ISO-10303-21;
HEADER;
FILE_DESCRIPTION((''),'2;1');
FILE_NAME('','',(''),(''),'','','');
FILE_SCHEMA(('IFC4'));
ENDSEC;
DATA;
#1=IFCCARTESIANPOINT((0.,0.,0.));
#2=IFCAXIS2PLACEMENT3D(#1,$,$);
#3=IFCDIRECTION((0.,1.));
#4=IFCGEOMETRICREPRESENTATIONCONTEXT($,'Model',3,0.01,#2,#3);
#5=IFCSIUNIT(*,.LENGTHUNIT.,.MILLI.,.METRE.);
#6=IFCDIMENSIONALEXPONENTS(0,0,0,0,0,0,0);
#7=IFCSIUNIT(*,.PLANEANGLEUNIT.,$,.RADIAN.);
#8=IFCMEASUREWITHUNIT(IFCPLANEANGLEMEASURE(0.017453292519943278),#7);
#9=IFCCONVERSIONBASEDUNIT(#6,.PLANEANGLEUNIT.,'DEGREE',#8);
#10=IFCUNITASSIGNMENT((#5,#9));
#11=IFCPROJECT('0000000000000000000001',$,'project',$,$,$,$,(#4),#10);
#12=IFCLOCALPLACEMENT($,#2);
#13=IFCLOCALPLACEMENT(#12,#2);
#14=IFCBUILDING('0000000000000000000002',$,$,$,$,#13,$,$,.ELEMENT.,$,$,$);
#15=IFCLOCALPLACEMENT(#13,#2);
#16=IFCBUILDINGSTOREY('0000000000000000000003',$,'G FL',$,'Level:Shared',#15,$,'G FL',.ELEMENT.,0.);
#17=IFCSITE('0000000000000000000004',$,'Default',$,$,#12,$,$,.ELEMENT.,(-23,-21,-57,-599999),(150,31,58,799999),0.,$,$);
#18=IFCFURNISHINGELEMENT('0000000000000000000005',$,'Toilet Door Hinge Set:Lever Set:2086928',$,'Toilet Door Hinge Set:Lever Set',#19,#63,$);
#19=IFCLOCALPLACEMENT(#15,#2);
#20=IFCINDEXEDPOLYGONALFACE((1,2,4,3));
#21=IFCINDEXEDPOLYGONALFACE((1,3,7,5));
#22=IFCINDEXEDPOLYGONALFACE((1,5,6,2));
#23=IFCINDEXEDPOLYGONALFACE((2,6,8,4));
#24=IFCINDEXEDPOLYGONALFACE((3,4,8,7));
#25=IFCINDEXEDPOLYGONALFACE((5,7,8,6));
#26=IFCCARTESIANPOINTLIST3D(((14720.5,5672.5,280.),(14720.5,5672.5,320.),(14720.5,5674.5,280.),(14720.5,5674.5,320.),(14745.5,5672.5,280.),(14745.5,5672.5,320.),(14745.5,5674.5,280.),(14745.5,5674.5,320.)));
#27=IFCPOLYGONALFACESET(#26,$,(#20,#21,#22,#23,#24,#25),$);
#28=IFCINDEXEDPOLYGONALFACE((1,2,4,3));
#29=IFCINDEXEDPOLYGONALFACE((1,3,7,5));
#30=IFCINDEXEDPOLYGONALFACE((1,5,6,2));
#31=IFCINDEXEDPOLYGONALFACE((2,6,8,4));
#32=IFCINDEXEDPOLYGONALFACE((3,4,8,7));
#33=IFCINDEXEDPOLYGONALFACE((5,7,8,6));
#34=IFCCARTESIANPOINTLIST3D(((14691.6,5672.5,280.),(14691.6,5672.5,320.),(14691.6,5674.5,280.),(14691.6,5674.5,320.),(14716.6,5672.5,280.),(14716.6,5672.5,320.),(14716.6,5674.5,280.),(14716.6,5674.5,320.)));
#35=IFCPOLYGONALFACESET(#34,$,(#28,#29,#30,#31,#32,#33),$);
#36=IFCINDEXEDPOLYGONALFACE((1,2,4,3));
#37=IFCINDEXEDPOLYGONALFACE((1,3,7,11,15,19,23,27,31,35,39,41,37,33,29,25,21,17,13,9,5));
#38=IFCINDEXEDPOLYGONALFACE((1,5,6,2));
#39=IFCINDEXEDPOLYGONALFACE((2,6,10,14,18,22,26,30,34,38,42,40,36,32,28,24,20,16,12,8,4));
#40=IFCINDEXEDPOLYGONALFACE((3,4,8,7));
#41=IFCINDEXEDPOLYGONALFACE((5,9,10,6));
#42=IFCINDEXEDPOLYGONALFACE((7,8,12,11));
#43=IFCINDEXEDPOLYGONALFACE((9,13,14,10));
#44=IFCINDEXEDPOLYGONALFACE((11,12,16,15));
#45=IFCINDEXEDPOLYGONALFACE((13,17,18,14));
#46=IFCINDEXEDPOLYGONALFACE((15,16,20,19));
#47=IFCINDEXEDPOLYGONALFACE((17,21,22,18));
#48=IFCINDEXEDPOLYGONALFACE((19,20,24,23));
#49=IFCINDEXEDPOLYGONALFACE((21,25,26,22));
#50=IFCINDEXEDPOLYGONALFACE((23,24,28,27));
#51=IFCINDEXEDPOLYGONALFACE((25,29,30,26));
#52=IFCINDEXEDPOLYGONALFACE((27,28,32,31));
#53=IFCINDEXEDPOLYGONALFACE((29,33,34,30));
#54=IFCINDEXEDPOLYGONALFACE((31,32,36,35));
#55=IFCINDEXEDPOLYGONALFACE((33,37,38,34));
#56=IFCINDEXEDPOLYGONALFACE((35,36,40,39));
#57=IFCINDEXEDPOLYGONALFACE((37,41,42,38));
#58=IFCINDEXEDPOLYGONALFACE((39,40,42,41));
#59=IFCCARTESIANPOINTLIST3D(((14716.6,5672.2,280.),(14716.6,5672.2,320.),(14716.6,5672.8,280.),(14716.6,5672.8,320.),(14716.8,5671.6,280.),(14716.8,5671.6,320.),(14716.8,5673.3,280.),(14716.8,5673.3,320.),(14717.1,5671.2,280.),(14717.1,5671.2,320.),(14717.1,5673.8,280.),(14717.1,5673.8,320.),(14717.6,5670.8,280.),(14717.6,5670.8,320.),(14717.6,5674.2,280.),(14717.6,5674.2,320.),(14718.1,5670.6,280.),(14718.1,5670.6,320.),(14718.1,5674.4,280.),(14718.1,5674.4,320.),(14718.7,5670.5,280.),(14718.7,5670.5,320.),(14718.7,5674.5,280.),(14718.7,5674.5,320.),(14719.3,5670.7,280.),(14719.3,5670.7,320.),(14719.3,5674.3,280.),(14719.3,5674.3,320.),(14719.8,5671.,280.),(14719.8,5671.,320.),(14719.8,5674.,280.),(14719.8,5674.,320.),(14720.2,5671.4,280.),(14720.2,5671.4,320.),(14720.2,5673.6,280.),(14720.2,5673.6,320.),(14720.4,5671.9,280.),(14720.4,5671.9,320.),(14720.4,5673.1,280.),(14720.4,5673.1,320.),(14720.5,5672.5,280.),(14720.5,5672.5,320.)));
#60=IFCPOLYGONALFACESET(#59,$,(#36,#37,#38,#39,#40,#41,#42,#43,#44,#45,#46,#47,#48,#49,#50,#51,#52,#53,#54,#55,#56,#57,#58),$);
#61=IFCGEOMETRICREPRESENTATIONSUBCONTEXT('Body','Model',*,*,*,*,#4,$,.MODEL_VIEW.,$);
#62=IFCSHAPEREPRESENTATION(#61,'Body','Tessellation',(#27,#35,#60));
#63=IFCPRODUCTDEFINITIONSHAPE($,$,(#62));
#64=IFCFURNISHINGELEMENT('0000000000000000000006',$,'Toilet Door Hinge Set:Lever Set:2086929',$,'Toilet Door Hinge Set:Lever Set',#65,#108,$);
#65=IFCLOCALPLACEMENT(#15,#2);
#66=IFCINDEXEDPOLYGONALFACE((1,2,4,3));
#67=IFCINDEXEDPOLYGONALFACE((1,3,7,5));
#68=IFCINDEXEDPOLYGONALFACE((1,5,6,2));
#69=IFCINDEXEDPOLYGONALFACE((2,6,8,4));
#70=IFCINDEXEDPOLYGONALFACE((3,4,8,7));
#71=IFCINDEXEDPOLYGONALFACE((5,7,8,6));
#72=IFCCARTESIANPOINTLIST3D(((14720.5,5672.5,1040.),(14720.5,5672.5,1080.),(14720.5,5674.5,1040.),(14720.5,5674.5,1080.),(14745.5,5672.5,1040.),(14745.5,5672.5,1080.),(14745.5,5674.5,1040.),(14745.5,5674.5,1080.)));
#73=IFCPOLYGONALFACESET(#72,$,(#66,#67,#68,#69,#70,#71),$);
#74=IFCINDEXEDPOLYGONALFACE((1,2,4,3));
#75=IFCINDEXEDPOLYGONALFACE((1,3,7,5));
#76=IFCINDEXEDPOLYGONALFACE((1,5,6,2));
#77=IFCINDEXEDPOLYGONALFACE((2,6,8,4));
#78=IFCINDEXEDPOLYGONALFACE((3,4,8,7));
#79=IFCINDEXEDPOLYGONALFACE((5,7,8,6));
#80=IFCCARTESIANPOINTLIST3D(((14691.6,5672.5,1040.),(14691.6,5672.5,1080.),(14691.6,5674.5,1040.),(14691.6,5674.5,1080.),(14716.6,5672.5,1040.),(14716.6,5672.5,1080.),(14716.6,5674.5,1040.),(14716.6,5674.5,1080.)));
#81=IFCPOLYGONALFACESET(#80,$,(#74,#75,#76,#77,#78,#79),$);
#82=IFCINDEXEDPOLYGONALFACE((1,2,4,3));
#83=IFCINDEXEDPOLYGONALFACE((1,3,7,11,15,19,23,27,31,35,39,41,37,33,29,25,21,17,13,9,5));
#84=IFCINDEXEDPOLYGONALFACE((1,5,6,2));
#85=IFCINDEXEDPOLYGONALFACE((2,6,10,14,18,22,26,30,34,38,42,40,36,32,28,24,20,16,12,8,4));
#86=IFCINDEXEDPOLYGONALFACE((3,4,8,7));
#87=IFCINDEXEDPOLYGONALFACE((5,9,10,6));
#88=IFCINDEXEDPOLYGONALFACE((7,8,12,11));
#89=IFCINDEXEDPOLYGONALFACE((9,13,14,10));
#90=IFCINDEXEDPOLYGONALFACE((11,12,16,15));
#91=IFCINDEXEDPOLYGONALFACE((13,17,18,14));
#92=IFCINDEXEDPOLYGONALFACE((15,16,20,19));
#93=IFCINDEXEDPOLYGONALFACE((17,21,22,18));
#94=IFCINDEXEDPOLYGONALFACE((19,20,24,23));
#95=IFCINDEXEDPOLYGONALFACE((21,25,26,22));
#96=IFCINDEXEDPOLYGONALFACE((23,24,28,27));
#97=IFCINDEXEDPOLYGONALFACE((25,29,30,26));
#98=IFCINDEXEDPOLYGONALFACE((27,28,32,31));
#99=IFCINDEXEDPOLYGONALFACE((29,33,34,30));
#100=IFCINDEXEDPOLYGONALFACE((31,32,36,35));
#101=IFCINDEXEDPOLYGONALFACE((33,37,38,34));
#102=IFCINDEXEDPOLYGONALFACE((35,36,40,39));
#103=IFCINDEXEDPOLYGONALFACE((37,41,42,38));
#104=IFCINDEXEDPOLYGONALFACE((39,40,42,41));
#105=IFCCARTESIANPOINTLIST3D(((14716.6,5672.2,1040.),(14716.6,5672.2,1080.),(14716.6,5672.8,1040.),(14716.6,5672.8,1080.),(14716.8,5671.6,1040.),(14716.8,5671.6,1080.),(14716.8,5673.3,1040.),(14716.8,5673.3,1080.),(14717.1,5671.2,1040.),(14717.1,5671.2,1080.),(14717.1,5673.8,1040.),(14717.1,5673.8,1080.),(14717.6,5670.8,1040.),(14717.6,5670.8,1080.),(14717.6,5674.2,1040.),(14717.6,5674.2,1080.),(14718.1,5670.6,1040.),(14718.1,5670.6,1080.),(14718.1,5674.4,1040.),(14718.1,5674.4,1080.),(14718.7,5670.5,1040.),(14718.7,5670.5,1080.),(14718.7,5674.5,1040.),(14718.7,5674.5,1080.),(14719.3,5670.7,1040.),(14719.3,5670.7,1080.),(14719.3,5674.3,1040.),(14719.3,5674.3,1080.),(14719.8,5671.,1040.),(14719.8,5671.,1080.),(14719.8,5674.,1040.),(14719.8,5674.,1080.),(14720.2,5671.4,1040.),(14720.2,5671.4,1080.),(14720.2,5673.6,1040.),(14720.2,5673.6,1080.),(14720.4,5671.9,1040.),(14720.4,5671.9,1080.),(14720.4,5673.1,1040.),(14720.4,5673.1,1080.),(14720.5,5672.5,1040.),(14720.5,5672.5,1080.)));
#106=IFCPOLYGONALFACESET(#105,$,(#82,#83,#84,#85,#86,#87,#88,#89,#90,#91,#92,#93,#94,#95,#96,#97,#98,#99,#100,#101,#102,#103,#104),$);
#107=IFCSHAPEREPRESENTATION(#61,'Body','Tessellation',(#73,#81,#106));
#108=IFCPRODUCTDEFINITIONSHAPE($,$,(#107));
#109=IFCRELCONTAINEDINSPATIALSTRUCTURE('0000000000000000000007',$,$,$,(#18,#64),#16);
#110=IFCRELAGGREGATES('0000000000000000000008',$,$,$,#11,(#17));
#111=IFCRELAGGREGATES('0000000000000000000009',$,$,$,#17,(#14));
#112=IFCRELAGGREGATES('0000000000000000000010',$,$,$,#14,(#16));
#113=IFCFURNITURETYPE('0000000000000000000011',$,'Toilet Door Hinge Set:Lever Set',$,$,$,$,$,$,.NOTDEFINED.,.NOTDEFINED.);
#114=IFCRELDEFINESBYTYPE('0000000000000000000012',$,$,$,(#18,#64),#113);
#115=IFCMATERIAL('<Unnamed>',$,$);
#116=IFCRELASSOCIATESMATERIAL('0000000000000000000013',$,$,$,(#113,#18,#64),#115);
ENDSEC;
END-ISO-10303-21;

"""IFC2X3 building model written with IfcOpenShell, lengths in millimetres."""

from ifc_helpers import new_model, entity, si_unit, converted_unit, direction, frame, frame_2d, origin, place, context, subcontext, project, spatial, rectangle, circle, extrude, source, transform, mapped, material, type_object, type_shapes, element, save


model = new_model("IFC2X3")

# Units and contexts
model_context = context("Model", 3, precision=0.01, world=origin(), true_north=direction((0.0, 1.0)))
body_context = subcontext(model_context, "Body", "Model", "MODEL_VIEW")
ifc_project = project(units=[si_unit("LENGTHUNIT", "METRE", prefix="MILLI"), converted_unit("PLANEANGLEUNIT", "DEGREE", entity("IfcPlaneAngleMeasure", 0.017453292519943278), si_unit("PLANEANGLEUNIT", "RADIAN"), dimensions=[0, 0, 0, 0, 0, 0, 0])], contexts=[model_context])

# Site, building, storey
site_placement = place(None, origin())
site = spatial("IfcSite", under=ifc_project, at=site_placement, Name="Default", CompositionType="ELEMENT", RefLatitude=(-23, -21, -57, -599999), RefLongitude=(150, 31, 58, 799999), RefElevation=0.0)
building_placement = place(site_placement, origin())
building = spatial("IfcBuilding", under=site, at=building_placement, CompositionType="ELEMENT")
storey_placement = place(building_placement, origin())
storey = spatial("IfcBuildingStorey", under=building, at=storey_placement, Name="G FL", ObjectType="Level:Shared", LongName="G FL", CompositionType="ELEMENT", Elevation=0.0)

# Furnishing elements
ifc_material_1 = material(Name="<Unnamed>")
furniture_type = type_object("IfcFurnitureType", Name="Toilet Door Hinge Set:Lever Set", AssemblyPlace="NOTDEFINED", material=ifc_material_1)
shared_shape_1 = source(origin(), body_context, "Body", "SweptSolid", [
    extrude(rectangle(XDim=2.0, YDim=25.0, at=frame_2d((0.0, 0.0), x_axis=(1.0, 0.0))), frame((14.5, 1.0, -20.0), z_axis=(0.0, 0.0, 1.0), x_axis=(0.0, 1.0, 0.0)), (0.0, 0.0, 1.0), 40.0),
    extrude(rectangle(XDim=25.0, YDim=2.0, at=frame_2d((0.0, 0.0), x_axis=(1.0, 0.0))), frame((-14.5, 1.0, -20.0)), (0.0, 0.0, 1.0), 40.0),
    extrude(circle(Radius=2.0, at=frame_2d((0.0, 0.0), x_axis=(1.0, 0.0))), frame((0.0, 0.0, -20.0)), (0.0, 0.0, 1.0), 40.0),
])
type_shapes(furniture_type, [shared_shape_1])
for number, where, name in (
    (1, (14718.5, 5672.5, 300.0), "Toilet Door Hinge Set:Lever Set:2086928"),
    (2, (14718.5, 5672.5, 1060.0), "Toilet Door Hinge Set:Lever Set:2086929"),
):
    element("IfcFurnishingElement", number, at=place(storey_placement, frame(where)), inside=storey, type_object=furniture_type, material=ifc_material_1, Name=name, ObjectType="Toilet Door Hinge Set:Lever Set", context=body_context, shape_type="MappedRepresentation", body=[
        mapped(shared_shape_1, transform((0.0, 0.0, 0.0), scale=1.0)),
    ])

save(model, "model.ifc")
